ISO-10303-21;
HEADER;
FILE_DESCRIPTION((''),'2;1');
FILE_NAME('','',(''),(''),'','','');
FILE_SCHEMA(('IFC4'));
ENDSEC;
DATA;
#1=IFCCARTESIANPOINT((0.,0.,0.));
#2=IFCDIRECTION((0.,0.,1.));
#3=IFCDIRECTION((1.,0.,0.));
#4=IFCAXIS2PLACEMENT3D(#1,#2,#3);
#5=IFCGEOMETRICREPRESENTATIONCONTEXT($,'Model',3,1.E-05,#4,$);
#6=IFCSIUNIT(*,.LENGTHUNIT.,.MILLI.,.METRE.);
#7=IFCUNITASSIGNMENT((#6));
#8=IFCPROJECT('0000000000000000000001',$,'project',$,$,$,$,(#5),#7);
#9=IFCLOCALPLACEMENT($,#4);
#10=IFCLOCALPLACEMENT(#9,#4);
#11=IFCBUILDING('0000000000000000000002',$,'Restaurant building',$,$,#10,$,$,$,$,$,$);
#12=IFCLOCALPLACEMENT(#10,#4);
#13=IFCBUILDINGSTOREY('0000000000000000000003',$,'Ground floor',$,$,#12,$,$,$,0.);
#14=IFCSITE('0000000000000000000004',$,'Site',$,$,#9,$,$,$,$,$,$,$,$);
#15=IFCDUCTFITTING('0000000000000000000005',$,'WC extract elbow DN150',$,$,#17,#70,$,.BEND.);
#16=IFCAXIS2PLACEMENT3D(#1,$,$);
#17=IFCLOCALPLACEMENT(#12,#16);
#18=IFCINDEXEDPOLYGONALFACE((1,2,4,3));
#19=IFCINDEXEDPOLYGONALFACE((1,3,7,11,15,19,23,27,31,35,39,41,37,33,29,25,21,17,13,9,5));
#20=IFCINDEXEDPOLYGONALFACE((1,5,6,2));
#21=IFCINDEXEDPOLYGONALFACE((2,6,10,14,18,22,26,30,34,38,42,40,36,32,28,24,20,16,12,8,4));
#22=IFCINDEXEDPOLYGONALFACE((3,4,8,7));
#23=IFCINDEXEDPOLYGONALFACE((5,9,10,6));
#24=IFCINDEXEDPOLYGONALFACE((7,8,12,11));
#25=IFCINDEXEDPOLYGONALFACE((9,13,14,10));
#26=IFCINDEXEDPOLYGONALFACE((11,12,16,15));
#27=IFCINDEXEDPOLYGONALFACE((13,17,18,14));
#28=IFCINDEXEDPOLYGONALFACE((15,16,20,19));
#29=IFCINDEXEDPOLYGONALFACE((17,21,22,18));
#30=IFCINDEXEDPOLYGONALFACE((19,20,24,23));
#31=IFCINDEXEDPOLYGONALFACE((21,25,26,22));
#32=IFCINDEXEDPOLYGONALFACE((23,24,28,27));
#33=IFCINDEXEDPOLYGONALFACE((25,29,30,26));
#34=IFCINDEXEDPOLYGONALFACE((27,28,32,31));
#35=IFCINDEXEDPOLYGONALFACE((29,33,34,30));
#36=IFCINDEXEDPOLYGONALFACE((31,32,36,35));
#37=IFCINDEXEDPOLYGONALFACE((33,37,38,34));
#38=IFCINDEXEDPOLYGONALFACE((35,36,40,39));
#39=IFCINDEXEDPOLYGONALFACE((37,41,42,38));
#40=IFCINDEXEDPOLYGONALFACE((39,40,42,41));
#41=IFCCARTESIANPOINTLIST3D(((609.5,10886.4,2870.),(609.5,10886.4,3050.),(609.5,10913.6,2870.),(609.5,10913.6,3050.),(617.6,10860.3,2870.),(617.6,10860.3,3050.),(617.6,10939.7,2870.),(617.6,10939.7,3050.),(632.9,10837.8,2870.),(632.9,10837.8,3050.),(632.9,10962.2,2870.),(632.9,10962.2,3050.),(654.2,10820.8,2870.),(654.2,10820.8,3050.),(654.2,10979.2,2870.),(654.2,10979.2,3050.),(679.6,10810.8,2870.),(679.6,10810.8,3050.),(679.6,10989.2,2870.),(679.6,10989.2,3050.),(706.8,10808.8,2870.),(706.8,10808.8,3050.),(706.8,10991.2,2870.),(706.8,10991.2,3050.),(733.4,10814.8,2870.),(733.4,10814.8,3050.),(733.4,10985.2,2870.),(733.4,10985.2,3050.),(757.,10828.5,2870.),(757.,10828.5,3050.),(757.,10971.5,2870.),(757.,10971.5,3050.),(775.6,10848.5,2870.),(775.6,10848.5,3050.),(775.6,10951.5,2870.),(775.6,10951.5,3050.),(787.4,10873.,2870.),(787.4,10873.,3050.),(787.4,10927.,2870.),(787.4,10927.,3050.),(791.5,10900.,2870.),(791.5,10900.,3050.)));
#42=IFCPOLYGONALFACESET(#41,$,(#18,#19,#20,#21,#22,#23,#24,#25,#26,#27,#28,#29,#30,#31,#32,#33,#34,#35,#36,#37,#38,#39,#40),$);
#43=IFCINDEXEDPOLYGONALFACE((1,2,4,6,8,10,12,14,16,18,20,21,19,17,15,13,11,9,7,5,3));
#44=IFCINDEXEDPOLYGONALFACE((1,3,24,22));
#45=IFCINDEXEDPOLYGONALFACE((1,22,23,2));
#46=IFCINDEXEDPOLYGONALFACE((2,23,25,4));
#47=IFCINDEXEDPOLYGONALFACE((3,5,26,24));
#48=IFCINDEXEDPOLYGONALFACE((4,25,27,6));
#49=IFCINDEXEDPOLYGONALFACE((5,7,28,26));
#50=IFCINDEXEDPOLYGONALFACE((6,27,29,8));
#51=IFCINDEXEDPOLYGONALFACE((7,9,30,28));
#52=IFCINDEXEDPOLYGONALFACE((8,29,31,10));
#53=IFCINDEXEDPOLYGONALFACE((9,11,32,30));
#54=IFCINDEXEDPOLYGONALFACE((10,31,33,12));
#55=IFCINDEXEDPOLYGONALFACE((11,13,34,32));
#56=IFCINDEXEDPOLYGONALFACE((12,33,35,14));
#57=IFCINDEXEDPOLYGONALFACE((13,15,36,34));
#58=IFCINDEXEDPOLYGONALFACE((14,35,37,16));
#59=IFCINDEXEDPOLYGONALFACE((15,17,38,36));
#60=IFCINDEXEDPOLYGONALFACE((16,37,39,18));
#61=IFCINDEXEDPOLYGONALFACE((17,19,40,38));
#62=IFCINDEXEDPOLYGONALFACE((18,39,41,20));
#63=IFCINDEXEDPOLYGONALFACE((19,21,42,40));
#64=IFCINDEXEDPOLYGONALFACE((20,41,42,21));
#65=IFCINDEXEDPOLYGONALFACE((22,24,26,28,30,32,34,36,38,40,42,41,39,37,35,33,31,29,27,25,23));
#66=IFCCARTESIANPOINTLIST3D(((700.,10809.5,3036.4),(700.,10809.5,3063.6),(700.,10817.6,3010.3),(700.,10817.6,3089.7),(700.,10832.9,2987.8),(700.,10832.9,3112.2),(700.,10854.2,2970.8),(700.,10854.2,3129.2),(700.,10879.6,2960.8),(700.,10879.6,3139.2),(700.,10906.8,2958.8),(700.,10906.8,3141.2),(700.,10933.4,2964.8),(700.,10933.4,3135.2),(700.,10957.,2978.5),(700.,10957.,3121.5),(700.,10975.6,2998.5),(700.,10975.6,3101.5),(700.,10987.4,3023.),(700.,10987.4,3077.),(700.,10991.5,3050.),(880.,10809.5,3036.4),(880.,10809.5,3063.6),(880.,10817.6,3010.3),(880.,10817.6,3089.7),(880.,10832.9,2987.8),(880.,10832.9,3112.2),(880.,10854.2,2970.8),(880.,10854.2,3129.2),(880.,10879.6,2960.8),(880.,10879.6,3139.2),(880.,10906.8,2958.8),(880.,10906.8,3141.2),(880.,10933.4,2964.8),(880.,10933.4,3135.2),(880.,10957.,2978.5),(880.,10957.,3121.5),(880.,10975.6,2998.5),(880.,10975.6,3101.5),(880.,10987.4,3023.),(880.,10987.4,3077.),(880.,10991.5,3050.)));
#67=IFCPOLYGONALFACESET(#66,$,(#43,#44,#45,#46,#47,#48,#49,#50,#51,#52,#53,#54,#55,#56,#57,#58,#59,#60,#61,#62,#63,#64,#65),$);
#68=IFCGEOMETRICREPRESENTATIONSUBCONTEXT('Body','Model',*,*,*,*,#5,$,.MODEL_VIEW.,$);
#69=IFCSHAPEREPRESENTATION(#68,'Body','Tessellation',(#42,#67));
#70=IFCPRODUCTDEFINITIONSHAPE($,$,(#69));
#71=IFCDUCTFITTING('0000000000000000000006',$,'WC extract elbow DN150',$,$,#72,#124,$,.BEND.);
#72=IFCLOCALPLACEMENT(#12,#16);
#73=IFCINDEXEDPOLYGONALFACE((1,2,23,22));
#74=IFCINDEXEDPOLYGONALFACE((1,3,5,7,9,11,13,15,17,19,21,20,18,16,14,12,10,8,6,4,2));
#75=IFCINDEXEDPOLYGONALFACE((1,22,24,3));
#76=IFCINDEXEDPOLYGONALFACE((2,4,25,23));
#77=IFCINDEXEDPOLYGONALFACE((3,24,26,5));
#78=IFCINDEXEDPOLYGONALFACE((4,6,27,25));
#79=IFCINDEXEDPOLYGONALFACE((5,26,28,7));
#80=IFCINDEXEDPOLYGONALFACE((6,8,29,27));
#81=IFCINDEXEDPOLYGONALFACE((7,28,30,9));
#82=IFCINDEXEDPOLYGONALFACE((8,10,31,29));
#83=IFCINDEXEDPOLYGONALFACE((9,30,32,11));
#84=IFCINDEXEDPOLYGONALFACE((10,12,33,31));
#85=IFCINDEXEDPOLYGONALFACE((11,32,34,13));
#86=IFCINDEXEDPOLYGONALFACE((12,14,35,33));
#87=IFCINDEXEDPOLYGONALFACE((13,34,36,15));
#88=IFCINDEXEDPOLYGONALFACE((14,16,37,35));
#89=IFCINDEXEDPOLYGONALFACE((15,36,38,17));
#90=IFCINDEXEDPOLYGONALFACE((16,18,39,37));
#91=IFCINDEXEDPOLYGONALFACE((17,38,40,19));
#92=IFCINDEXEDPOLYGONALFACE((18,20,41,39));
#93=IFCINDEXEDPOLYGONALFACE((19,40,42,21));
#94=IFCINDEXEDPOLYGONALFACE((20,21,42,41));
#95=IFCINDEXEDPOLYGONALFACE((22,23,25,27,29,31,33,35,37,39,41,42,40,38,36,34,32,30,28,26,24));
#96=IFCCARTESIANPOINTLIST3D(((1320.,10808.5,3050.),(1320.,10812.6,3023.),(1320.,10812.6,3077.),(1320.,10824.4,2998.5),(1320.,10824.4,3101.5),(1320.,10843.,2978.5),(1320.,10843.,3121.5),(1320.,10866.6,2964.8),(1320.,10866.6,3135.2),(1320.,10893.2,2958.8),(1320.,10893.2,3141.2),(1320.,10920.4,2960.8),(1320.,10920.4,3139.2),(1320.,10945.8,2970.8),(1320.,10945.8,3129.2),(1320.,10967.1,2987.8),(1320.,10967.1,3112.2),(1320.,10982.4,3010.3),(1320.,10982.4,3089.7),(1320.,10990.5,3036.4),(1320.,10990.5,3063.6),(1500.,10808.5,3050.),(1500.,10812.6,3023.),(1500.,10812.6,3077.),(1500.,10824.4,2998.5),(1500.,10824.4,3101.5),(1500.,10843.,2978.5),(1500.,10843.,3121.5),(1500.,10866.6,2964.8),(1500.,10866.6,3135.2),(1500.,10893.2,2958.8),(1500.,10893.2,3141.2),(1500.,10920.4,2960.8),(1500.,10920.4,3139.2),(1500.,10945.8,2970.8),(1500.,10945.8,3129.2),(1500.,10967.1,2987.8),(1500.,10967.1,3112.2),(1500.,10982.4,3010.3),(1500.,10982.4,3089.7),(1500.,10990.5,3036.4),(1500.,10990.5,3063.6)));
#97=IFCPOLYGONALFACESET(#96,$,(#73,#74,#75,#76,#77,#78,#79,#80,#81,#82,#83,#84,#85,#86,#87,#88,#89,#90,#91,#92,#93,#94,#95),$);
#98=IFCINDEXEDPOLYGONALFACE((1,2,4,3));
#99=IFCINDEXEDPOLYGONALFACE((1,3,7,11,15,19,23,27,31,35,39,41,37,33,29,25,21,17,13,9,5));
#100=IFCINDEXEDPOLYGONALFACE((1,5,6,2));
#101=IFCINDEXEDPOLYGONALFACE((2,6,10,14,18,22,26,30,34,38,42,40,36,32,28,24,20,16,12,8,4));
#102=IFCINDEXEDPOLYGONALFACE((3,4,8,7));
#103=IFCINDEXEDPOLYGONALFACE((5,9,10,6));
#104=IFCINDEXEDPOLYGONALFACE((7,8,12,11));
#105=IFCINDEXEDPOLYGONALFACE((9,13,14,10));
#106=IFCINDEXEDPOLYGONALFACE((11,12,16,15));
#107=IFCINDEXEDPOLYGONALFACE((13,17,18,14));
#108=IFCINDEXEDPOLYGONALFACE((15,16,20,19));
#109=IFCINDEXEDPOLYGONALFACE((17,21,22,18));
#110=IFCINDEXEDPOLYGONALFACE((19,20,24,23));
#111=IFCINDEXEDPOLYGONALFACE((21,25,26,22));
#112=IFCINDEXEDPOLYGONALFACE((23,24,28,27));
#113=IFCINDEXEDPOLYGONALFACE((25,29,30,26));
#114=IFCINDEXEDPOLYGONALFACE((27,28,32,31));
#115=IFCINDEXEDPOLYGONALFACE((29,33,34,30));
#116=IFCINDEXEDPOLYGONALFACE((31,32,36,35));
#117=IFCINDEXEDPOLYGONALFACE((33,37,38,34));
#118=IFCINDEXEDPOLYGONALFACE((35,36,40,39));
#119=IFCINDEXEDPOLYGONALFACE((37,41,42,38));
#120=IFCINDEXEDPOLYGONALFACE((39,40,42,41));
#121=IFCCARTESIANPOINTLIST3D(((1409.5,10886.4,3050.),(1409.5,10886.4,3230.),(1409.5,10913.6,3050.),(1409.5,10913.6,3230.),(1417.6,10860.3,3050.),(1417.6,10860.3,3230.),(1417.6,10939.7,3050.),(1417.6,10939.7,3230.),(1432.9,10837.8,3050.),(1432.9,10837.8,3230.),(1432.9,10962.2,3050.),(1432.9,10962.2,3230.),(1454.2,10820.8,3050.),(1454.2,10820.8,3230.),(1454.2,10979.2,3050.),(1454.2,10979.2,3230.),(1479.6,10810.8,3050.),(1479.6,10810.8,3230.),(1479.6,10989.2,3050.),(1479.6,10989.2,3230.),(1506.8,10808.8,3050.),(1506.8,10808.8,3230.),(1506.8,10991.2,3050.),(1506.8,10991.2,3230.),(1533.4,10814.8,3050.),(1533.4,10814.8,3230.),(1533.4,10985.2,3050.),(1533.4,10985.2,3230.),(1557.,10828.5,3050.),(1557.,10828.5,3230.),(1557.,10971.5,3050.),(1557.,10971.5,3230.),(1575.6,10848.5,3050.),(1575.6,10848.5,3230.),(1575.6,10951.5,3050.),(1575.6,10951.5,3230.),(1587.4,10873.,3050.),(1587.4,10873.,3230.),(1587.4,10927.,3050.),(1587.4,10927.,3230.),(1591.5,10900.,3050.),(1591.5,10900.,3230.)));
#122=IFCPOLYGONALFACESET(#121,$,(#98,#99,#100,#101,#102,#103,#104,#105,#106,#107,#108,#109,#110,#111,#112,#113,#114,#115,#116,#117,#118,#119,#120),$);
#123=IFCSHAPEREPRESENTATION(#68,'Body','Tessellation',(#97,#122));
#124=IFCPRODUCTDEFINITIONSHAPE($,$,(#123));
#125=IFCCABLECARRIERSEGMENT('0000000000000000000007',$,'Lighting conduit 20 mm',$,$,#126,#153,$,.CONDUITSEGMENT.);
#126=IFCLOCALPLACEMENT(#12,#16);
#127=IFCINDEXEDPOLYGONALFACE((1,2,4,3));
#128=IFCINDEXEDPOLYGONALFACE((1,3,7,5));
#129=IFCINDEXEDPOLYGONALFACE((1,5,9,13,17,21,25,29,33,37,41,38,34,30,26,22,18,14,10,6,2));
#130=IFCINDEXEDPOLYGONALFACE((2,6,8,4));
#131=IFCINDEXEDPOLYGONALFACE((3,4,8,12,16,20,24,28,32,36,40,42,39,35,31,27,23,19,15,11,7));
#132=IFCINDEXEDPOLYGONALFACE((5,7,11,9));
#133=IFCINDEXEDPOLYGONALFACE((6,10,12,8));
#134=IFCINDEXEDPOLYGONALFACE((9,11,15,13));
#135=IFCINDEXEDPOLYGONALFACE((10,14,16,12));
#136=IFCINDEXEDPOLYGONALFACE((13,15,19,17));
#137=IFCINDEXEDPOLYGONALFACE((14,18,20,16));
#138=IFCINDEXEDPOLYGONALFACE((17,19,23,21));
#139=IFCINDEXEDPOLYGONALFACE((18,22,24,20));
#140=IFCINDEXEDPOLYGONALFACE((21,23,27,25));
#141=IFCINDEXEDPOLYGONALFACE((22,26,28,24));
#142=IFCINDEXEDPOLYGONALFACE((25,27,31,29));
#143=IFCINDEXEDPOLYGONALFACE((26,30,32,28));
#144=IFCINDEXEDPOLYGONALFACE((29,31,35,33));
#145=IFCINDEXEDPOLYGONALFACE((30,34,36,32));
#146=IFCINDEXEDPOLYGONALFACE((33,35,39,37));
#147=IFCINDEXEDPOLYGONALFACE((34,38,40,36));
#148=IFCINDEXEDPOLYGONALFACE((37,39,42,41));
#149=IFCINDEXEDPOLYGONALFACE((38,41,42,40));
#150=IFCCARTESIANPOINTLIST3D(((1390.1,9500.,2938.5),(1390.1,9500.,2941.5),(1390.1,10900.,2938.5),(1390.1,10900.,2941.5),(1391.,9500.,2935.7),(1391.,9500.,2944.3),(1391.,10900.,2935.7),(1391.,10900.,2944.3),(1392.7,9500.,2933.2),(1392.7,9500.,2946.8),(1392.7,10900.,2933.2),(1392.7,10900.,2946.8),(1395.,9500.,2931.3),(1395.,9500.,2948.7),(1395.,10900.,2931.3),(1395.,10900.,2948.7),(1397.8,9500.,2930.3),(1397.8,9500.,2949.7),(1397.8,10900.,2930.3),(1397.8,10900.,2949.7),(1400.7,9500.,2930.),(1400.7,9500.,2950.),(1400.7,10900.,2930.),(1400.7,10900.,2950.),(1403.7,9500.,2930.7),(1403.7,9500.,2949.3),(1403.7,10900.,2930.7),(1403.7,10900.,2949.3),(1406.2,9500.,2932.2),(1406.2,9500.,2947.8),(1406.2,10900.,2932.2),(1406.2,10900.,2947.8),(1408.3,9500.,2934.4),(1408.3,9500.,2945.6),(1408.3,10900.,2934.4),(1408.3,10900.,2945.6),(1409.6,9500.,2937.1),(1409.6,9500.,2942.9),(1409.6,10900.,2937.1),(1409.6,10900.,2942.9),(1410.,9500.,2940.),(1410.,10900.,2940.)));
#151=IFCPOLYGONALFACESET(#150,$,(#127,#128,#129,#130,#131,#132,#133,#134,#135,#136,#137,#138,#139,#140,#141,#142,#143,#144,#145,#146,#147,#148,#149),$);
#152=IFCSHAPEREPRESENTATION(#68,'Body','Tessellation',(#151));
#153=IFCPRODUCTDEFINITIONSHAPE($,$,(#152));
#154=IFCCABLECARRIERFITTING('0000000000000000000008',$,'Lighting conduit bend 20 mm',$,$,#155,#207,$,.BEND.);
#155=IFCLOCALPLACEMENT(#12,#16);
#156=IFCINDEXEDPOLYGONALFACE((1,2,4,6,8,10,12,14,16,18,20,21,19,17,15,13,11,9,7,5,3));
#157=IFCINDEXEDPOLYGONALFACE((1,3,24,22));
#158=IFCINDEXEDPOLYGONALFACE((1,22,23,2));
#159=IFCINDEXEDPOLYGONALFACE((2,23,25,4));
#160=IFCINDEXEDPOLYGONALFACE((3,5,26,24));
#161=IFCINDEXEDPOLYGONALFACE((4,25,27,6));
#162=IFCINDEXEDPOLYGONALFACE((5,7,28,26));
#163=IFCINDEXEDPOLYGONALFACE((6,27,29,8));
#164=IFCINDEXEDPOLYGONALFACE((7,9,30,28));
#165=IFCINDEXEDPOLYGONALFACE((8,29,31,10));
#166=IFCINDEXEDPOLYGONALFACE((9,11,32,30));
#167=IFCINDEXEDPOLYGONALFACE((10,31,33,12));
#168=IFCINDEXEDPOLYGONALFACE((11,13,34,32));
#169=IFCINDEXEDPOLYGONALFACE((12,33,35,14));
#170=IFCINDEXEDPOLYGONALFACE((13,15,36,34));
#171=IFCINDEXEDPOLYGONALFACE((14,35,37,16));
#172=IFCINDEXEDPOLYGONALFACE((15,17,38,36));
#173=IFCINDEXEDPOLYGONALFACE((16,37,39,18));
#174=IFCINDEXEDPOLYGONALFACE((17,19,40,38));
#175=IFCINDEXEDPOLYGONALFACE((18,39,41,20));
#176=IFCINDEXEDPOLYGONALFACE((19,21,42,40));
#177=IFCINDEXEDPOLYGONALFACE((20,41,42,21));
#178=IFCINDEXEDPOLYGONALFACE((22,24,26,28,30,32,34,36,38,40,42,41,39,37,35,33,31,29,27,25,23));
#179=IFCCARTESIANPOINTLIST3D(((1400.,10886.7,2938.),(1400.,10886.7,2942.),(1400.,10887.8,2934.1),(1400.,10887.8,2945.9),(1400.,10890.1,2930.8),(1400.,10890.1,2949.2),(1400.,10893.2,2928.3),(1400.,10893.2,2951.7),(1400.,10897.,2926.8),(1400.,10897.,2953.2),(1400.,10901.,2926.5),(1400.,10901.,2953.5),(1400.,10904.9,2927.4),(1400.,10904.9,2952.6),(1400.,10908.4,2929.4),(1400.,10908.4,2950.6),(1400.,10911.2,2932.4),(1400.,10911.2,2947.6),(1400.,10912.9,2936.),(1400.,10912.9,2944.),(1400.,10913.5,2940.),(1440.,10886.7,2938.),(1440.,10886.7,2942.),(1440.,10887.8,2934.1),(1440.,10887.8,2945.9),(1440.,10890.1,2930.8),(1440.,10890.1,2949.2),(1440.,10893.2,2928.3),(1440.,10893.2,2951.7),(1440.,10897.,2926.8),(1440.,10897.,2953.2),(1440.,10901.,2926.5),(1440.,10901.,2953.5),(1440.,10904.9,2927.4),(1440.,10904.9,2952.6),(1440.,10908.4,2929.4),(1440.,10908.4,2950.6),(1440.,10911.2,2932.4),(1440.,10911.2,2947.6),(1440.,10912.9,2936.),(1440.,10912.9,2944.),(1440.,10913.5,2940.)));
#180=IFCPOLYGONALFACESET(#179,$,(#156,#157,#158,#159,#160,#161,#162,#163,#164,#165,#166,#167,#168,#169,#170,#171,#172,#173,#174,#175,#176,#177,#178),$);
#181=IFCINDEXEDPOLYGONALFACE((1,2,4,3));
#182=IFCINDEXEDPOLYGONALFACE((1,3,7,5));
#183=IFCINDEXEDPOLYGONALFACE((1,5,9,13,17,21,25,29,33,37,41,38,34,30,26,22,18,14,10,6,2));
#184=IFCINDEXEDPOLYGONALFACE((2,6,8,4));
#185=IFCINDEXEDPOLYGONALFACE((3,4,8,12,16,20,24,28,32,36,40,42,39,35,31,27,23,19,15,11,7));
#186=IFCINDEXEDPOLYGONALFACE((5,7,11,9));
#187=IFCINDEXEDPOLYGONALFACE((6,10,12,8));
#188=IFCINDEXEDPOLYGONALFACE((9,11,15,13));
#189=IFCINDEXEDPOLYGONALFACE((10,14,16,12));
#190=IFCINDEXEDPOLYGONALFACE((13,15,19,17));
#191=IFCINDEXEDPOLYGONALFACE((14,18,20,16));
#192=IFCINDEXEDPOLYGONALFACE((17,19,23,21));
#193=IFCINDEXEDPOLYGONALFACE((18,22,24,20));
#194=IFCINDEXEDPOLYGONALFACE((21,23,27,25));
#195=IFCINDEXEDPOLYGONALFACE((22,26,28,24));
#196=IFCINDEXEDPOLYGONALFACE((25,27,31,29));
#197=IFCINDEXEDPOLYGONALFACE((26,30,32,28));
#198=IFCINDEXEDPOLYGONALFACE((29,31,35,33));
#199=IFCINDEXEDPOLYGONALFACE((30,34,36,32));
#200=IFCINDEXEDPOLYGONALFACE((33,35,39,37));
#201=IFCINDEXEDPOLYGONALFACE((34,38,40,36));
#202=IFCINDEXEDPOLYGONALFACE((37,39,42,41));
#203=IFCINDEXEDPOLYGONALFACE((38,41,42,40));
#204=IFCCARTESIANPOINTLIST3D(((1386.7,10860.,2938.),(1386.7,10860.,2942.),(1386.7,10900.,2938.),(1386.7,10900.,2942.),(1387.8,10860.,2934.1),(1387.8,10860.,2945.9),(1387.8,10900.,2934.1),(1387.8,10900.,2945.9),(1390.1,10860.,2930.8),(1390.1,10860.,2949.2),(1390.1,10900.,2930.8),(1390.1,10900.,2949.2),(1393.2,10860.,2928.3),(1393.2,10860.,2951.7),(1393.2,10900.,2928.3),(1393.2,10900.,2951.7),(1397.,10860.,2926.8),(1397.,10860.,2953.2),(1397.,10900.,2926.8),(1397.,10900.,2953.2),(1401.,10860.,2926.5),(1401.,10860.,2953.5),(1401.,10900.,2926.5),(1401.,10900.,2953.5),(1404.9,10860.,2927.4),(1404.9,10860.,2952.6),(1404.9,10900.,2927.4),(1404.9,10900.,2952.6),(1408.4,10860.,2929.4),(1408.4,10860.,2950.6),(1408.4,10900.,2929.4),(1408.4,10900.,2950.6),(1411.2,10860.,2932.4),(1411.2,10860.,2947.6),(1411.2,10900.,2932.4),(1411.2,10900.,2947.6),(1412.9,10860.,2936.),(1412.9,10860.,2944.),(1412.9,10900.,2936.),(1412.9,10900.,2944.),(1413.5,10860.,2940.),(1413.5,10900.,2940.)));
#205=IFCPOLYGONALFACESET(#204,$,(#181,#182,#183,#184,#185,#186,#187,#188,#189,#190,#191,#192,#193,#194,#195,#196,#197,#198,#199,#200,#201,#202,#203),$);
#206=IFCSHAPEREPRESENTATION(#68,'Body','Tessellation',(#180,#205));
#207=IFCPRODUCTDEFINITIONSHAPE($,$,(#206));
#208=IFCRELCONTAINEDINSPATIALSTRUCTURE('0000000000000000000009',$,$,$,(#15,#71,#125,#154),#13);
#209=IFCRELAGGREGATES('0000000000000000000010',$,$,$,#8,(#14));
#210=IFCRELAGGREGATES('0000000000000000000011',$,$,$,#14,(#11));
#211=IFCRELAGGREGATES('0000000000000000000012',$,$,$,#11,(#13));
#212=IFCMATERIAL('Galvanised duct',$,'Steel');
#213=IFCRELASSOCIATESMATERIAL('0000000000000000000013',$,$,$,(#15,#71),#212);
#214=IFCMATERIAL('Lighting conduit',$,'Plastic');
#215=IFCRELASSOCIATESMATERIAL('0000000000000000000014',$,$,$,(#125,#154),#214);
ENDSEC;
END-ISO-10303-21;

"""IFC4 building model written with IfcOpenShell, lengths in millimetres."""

from ifc_helpers import new_model, si_unit, frame, origin, origin_with_axes, origin_2d, place, context, subcontext, project, spatial, circle, extrude, material, element, save


model = new_model("IFC4")

# Units and contexts
model_context = context("Model", 3, precision=1e-05, world=origin_with_axes())
body_context = subcontext(model_context, "Body", "Model", "MODEL_VIEW")
ifc_project = project(units=[si_unit("LENGTHUNIT", "METRE", prefix="MILLI")], contexts=[model_context])

# Site, building, storey
site_placement = place(None, origin_with_axes())
site = spatial("IfcSite", under=ifc_project, at=site_placement, Name="Site")
building_placement = place(site_placement, origin_with_axes())
building = spatial("IfcBuilding", under=site, at=building_placement, Name="Restaurant building")
storey_placement = place(building_placement, origin_with_axes())
storey = spatial("IfcBuildingStorey", under=building, at=storey_placement, Name="Ground floor", Elevation=0.0)

# Shared definitions
ifc_material_1 = material(Name="Galvanised duct", Category="Steel")

# Duct fittings
duct_fitting_1_placement = place(storey_placement, frame((700.0, 10900.0, 3050.0)))
element("IfcDuctFitting", 1, at=duct_fitting_1_placement, inside=storey, material=ifc_material_1, Name="WC extract elbow DN150", PredefinedType="BEND", context=body_context, shape_type="SweptSolid", body=[
    extrude(circle(Radius=91.5, at=origin_2d()), frame((0.0, 0.0, 0.0), z_axis=(0.0, 0.0, -1.0), x_axis=(1.0, 0.0, 0.0)), (0.0, 0.0, 1.0), 180.0),
    extrude(circle(Radius=91.5, at=origin_2d()), frame((0.0, 0.0, 0.0), z_axis=(1.0, 0.0, 0.0), x_axis=(0.0, 1.0, 0.0)), (0.0, 0.0, 1.0), 180.0),
])
duct_fitting_2_placement = place(storey_placement, frame((1500.0, 10900.0, 3050.0)))
element("IfcDuctFitting", 2, at=duct_fitting_2_placement, inside=storey, material=ifc_material_1, Name="WC extract elbow DN150", PredefinedType="BEND", context=body_context, shape_type="SweptSolid", body=[
    extrude(circle(Radius=91.5, at=origin_2d()), frame((0.0, 0.0, 0.0), z_axis=(-1.0, 0.0, 0.0), x_axis=(0.0, -1.0, 0.0)), (0.0, 0.0, 1.0), 180.0),
    extrude(circle(Radius=91.5, at=origin_2d()), origin(), (0.0, 0.0, 1.0), 180.0),
])

# Cable carrier segment
ifc_material_2 = material(Name="Lighting conduit", Category="Plastic")
cable_carrier_segment_1_placement = place(storey_placement, frame((1400.0, 10900.0, 2940.0)))
element("IfcCableCarrierSegment", 3, at=cable_carrier_segment_1_placement, inside=storey, material=ifc_material_2, Name="Lighting conduit 20 mm", PredefinedType="CONDUITSEGMENT", context=body_context, shape_type="SweptSolid", body=[
    extrude(circle(Radius=10.0, at=origin_2d()), frame((0.0, 0.0, 0.0), z_axis=(0.0, -1.0, 0.0), x_axis=(1.0, 0.0, 0.0)), (0.0, 0.0, 1.0), 1400.0),
])

# Cable carrier fitting
cable_carrier_fitting_1_placement = place(storey_placement, frame((1400.0, 10900.0, 2940.0)))
element("IfcCableCarrierFitting", 4, at=cable_carrier_fitting_1_placement, inside=storey, material=ifc_material_2, Name="Lighting conduit bend 20 mm", PredefinedType="BEND", context=body_context, shape_type="SweptSolid", body=[
    extrude(circle(Radius=13.5, at=origin_2d()), frame((0.0, 0.0, 0.0), z_axis=(1.0, 0.0, 0.0), x_axis=(0.0, 1.0, 0.0)), (0.0, 0.0, 1.0), 40.0),
    extrude(circle(Radius=13.5, at=origin_2d()), frame((0.0, 0.0, 0.0), z_axis=(0.0, -1.0, 0.0), x_axis=(1.0, 0.0, 0.0)), (0.0, 0.0, 1.0), 40.0),
])

save(model, "model.ifc")
